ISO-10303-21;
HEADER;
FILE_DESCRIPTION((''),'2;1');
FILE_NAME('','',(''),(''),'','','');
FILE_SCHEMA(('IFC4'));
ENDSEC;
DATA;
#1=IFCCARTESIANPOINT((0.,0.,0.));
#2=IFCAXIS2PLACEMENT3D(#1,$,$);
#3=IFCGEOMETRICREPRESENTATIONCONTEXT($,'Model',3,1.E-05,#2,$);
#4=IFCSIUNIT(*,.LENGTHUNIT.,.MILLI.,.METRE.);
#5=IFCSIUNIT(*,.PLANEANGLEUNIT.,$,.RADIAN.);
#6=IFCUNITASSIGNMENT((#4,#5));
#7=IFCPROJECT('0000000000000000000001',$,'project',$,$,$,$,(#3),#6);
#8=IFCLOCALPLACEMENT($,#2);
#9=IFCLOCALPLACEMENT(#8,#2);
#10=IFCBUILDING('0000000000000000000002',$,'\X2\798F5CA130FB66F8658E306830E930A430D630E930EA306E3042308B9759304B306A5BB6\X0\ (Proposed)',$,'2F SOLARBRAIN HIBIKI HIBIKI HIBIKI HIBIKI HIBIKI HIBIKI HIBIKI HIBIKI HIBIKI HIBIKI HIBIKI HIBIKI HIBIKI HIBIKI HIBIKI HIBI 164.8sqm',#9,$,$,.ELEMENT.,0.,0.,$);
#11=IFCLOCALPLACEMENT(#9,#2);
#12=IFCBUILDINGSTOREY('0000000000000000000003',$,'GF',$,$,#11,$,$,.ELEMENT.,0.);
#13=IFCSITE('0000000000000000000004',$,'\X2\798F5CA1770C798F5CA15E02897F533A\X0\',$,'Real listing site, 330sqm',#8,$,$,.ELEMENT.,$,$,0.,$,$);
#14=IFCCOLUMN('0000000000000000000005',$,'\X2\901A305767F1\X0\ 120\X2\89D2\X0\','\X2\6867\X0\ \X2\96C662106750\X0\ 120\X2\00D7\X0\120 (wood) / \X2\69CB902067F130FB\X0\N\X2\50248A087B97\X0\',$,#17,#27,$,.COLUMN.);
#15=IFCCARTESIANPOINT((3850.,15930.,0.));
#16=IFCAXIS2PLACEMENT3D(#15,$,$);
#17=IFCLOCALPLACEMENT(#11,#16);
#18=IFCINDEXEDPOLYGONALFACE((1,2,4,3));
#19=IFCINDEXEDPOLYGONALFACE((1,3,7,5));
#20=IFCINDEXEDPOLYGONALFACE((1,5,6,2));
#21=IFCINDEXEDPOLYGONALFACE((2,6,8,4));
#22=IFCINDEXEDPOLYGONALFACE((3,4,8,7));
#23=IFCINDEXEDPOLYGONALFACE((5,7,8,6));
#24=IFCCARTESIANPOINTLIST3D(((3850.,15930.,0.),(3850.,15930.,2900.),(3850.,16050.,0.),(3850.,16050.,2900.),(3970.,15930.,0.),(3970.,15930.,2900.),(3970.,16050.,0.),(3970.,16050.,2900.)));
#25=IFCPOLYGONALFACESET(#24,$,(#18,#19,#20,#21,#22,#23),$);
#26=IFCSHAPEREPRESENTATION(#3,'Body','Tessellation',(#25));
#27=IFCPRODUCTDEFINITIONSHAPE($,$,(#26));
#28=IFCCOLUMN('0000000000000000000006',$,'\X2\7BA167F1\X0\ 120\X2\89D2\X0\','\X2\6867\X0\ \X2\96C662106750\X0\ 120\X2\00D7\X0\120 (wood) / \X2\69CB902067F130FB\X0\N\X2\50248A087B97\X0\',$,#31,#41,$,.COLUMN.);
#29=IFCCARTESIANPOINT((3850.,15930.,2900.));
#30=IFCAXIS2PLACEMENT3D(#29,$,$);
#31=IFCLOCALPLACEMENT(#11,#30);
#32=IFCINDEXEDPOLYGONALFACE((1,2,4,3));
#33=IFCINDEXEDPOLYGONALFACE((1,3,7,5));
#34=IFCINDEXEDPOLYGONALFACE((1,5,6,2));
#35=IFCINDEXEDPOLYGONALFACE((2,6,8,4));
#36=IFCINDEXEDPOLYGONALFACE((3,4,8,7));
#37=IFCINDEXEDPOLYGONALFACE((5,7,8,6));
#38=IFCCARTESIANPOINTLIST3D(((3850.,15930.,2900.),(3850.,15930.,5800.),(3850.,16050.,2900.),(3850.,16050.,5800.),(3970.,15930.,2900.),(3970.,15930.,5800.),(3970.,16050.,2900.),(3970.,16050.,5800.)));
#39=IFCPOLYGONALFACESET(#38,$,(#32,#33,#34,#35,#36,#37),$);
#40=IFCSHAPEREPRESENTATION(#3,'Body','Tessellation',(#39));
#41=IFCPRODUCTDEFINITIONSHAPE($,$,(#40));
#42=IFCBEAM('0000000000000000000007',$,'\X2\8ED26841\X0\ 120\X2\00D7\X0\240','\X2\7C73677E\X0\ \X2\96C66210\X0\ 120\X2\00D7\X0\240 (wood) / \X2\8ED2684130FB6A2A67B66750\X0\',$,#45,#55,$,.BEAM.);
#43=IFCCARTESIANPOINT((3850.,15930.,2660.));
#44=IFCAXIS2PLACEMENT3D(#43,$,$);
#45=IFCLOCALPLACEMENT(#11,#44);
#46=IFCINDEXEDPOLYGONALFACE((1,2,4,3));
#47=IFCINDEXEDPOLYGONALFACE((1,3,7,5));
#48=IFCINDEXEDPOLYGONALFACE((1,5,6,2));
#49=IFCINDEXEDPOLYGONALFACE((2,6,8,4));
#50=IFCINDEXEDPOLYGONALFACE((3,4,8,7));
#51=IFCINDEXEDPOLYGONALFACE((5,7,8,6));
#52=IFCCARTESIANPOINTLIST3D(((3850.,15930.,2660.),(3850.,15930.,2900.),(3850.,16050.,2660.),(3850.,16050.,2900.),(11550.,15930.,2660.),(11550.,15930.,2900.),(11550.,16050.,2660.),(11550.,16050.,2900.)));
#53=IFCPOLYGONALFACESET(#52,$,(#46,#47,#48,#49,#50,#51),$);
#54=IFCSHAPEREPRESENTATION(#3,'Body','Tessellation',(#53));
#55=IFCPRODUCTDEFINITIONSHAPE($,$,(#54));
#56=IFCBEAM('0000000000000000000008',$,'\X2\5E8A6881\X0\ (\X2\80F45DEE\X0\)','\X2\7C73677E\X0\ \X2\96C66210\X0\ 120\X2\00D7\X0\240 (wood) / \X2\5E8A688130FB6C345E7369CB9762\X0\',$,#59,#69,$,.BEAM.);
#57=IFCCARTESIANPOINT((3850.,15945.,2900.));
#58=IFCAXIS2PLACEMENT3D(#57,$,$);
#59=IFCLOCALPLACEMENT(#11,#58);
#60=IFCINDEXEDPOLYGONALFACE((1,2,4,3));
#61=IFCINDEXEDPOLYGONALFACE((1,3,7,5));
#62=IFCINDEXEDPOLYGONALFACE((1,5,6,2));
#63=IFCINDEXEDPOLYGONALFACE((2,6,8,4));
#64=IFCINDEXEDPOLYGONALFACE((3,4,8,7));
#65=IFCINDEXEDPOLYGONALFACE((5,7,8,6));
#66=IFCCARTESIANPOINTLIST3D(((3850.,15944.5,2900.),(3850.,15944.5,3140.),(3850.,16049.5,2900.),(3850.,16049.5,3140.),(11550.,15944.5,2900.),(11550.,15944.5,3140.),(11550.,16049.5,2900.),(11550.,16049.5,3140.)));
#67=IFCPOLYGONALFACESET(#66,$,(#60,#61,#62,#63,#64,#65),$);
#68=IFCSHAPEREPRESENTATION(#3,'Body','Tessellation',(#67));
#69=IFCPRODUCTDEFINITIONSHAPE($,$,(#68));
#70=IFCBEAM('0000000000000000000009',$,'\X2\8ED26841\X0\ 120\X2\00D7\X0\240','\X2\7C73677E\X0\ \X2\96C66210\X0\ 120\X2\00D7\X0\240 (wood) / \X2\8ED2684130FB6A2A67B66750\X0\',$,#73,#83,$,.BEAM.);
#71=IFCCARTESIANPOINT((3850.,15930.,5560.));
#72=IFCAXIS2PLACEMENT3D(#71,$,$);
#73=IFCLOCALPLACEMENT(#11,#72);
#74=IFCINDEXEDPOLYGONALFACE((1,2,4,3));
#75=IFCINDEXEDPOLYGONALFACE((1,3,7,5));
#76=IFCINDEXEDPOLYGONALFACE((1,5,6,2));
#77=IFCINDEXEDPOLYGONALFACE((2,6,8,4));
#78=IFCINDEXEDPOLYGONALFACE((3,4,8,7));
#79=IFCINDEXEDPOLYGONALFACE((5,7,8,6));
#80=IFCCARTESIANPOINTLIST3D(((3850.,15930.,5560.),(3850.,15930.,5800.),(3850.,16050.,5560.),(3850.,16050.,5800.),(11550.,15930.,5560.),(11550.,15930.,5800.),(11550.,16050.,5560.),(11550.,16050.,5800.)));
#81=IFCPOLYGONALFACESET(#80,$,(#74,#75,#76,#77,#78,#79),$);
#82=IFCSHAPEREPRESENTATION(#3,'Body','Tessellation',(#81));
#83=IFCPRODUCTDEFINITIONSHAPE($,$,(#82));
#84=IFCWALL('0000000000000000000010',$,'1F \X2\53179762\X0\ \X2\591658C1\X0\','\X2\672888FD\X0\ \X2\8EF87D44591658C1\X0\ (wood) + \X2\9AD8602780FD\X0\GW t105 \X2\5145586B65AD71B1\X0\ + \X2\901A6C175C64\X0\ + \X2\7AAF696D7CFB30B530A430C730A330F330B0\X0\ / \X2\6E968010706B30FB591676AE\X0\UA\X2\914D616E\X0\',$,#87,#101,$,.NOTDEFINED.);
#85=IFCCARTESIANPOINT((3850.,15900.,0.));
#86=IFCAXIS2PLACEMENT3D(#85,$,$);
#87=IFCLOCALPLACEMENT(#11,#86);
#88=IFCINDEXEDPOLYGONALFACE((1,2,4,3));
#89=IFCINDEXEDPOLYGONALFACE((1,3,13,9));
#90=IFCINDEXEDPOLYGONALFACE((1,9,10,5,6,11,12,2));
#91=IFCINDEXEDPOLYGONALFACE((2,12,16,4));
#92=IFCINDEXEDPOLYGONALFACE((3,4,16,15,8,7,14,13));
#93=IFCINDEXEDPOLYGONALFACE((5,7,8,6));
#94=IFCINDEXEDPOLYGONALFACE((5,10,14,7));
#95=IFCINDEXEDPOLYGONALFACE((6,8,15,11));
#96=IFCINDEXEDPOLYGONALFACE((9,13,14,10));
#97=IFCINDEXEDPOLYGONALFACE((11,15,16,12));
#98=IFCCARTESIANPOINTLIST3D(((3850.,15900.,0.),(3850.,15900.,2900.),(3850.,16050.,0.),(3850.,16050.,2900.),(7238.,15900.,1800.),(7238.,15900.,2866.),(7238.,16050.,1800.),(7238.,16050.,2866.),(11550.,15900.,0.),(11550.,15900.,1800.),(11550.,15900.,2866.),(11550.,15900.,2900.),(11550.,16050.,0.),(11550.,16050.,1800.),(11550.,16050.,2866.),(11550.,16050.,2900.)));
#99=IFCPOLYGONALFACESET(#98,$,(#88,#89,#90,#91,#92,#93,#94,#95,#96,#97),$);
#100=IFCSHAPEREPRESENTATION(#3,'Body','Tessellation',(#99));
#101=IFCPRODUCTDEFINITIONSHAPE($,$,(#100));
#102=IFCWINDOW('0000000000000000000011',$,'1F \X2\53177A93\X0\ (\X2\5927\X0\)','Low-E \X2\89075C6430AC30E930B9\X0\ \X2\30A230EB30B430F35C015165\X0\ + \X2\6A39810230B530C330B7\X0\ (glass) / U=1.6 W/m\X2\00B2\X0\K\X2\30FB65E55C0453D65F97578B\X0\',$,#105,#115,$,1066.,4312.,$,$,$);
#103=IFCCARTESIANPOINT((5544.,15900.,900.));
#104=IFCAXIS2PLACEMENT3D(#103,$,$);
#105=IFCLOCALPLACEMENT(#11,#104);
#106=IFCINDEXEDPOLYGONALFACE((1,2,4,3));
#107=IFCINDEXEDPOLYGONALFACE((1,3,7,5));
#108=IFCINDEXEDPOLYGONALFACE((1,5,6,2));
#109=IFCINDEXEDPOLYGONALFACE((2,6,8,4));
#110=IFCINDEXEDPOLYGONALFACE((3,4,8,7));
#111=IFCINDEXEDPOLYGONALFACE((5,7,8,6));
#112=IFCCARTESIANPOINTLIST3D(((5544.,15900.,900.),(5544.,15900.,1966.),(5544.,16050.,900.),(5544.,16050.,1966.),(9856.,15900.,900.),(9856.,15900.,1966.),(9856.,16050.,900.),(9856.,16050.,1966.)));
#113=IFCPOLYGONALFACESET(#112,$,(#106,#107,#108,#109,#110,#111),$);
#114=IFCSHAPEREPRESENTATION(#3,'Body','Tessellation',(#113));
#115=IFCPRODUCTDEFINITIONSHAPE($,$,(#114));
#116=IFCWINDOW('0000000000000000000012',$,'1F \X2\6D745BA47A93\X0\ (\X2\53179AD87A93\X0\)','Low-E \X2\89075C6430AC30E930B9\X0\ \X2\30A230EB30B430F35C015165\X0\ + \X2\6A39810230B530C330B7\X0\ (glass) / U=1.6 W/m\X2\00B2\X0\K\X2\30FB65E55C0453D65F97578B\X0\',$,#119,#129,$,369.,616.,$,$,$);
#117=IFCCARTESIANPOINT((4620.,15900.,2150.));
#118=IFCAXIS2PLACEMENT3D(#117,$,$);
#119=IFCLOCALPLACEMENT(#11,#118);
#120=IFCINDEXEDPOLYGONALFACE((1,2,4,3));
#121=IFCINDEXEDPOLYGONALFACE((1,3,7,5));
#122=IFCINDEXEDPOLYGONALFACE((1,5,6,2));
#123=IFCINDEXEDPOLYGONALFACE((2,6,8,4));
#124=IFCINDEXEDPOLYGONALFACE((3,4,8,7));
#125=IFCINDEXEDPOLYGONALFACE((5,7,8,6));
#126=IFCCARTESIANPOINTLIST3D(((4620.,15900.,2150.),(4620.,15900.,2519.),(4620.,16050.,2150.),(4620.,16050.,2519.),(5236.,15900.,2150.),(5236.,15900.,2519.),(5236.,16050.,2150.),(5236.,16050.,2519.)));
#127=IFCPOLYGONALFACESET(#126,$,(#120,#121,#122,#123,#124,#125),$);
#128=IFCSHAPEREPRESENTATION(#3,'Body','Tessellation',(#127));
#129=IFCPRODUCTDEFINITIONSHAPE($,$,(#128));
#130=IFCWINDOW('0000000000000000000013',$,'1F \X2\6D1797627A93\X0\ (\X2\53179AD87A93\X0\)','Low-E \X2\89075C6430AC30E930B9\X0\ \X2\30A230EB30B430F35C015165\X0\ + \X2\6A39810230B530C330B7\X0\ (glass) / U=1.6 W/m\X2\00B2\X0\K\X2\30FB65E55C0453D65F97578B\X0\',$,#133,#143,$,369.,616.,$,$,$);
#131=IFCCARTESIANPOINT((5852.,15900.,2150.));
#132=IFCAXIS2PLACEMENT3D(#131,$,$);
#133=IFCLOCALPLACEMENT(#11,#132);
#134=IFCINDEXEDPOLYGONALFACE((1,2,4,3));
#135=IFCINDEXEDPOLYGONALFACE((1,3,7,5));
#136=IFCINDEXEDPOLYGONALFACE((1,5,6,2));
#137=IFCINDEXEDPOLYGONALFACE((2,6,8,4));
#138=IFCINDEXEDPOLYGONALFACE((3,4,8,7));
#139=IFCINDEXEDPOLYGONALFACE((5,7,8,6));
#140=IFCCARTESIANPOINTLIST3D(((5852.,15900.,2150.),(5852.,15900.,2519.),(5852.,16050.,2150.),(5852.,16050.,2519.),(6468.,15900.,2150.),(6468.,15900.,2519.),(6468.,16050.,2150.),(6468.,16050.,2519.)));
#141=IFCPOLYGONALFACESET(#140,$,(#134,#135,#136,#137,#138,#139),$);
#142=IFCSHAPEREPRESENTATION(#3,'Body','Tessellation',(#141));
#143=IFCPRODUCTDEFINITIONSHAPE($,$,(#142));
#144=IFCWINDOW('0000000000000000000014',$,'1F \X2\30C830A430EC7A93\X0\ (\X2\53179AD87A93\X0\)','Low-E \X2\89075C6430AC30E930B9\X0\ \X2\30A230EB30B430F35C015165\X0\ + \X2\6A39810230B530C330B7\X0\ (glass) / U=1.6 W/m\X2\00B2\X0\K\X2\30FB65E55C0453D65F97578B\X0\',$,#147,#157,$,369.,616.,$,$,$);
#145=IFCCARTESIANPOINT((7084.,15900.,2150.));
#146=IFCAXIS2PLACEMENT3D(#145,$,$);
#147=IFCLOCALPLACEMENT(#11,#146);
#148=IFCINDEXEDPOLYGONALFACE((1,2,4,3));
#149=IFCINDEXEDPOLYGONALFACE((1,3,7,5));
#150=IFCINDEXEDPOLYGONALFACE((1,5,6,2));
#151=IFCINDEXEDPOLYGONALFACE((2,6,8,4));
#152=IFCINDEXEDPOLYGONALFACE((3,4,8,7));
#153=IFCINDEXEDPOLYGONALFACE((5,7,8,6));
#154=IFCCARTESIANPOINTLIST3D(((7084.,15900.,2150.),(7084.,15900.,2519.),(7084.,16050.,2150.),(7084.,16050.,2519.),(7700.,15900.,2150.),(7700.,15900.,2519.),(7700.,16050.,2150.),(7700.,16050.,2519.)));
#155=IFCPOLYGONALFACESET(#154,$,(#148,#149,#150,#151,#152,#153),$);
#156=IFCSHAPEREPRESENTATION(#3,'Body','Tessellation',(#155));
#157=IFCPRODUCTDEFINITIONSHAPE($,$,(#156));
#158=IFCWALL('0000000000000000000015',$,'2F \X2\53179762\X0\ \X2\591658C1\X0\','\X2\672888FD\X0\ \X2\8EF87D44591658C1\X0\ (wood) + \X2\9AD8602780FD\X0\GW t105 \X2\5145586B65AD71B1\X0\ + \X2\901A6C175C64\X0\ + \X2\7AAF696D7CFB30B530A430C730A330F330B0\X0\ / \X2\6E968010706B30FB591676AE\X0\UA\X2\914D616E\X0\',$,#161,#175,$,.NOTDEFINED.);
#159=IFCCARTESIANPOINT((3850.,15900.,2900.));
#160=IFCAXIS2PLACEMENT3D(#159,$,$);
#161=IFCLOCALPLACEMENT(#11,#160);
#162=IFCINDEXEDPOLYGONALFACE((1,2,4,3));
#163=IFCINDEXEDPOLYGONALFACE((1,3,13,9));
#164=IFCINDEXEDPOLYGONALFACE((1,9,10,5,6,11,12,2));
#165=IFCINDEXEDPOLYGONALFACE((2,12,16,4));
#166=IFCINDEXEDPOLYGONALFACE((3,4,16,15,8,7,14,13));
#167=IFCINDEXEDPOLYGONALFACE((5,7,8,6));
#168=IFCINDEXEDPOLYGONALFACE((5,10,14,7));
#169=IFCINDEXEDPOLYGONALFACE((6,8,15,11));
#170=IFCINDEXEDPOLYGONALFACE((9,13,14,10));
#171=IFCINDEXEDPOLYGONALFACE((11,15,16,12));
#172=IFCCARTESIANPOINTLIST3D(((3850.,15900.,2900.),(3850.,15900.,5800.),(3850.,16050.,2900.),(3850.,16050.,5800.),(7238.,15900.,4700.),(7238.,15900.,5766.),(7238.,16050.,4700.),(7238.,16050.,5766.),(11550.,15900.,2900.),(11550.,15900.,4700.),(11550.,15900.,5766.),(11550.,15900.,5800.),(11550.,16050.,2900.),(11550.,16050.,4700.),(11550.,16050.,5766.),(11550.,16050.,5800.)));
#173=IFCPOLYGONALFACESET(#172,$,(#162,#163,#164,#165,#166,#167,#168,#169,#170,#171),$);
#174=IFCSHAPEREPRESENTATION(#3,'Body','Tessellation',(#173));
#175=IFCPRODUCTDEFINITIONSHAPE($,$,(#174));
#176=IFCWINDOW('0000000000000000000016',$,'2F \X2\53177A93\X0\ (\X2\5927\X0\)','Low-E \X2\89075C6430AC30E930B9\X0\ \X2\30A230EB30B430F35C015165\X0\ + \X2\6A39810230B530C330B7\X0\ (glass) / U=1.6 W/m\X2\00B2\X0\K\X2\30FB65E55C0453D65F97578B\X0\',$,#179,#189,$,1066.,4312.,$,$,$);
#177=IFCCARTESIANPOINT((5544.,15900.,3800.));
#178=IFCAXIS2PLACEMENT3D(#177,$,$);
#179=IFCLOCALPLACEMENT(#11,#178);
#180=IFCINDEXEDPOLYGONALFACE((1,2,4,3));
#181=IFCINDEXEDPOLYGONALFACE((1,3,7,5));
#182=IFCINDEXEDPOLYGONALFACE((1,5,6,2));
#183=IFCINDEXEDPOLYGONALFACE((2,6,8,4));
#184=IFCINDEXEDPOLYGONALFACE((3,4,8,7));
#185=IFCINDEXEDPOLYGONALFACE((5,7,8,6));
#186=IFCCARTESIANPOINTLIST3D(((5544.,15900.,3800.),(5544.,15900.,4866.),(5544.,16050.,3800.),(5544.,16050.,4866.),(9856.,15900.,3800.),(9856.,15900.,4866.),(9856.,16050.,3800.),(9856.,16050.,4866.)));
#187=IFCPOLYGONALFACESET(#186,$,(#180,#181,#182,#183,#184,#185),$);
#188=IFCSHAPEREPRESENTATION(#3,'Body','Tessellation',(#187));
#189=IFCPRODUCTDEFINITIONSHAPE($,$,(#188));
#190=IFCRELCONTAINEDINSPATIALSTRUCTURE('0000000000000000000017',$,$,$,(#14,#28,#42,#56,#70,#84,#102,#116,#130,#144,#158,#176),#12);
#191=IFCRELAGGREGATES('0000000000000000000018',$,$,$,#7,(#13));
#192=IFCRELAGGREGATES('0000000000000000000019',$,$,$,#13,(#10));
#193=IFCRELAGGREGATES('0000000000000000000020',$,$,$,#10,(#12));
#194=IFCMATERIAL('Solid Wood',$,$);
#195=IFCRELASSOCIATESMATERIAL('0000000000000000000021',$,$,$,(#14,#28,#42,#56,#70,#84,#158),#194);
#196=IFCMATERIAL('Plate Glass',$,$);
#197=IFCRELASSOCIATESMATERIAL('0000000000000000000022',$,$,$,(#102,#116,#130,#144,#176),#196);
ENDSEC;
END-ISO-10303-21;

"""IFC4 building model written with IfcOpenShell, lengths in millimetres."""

from ifc_helpers import new_model, si_unit, frame, frame_2d, origin, place, context, project, spatial, rectangle, extrude, material, element, fill, save


model = new_model("IFC4")

# Units and contexts
model_context = context("Model", 3, precision=1e-05, world=origin())
ifc_project = project(units=[si_unit("LENGTHUNIT", "METRE", prefix="MILLI"), si_unit("PLANEANGLEUNIT", "RADIAN")], contexts=[model_context])

# Site, building, storey
site_placement = place(None, origin())
site = spatial("IfcSite", under=ifc_project, at=site_placement, Name="福岡県福岡市西区", ObjectType="Real listing site, 330sqm", CompositionType="ELEMENT", RefElevation=0.0)
building_placement = place(site_placement, origin())
building = spatial("IfcBuilding", under=site, at=building_placement, Name="福岡・書斎とライブラリのある静かな家 (Proposed)", ObjectType="2F SOLARBRAIN HIBIKI HIBIKI HIBIKI HIBIKI HIBIKI HIBIKI HIBIKI HIBIKI HIBIKI HIBIKI HIBIKI HIBIKI HIBIKI HIBIKI HIBIKI HIBI 164.8sqm", CompositionType="ELEMENT", ElevationOfRefHeight=0.0, ElevationOfTerrain=0.0)
storey_placement = place(building_placement, origin())
storey = spatial("IfcBuildingStorey", under=building, at=storey_placement, Name="GF", CompositionType="ELEMENT", Elevation=0.0)

# Columns
ifc_material_1 = material(Name="Solid Wood")
column_1_placement = place(storey_placement, frame((3850.0, 15930.0, 0.0)))
element("IfcColumn", 1, at=column_1_placement, inside=storey, material=ifc_material_1, Name="通し柱 120角", Description="桧 集成材 120×120 (wood) / 構造柱・N値計算", PredefinedType="COLUMN", context=model_context, shape_type="SweptSolid", body=[
    extrude(rectangle(XDim=120.0, YDim=120.0, at=frame_2d((60.0, 60.0))), frame((3850.0, 15930.0, 0.0)), (0.0, 0.0, 1.0), 2900.0),
])
column_2_placement = place(storey_placement, frame((3850.0, 15930.0, 2900.0)))
element("IfcColumn", 2, at=column_2_placement, inside=storey, material=ifc_material_1, Name="管柱 120角", Description="桧 集成材 120×120 (wood) / 構造柱・N値計算", PredefinedType="COLUMN", context=model_context, shape_type="SweptSolid", body=[
    extrude(rectangle(XDim=120.0, YDim=120.0, at=frame_2d((60.0, 60.0))), frame((3850.0, 15930.0, 2900.0)), (0.0, 0.0, 1.0), 2900.0),
])

# Beams
beam_1_placement = place(storey_placement, frame((3850.0, 15930.0, 2660.0)))
element("IfcBeam", 3, at=beam_1_placement, inside=storey, material=ifc_material_1, Name="軒桁 120×240", Description="米松 集成 120×240 (wood) / 軒桁・横架材", PredefinedType="BEAM", context=model_context, shape_type="SweptSolid", body=[
    extrude(rectangle(XDim=7700.0, YDim=120.0, at=frame_2d((3850.0, 60.0))), frame((3850.0, 15930.0, 2660.0)), (0.0, 0.0, 1.0), 240.0),
])
beam_2_placement = place(storey_placement, frame((3850.0, 15945.0, 2900.0)))
element("IfcBeam", 4, at=beam_2_placement, inside=storey, material=ifc_material_1, Name="床梁 (胴差)", Description="米松 集成 120×240 (wood) / 床梁・水平構面", PredefinedType="BEAM", context=model_context, shape_type="SweptSolid", body=[
    extrude(rectangle(XDim=7700.0, YDim=105.0, at=frame_2d((3850.0, 52.0))), frame((3850.0, 15945.0, 2900.0)), (0.0, 0.0, 1.0), 240.0),
])
beam_3_placement = place(storey_placement, frame((3850.0, 15930.0, 5560.0)))
element("IfcBeam", 5, at=beam_3_placement, inside=storey, material=ifc_material_1, Name="軒桁 120×240", Description="米松 集成 120×240 (wood) / 軒桁・横架材", PredefinedType="BEAM", context=model_context, shape_type="SweptSolid", body=[
    extrude(rectangle(XDim=7700.0, YDim=120.0, at=frame_2d((3850.0, 60.0))), frame((3850.0, 15930.0, 5560.0)), (0.0, 0.0, 1.0), 240.0),
])

# Wall, openings, windows
wall_1_placement = place(storey_placement, frame((3850.0, 15900.0, 0.0)))
wall_1 = element("IfcWall", 6, at=wall_1_placement, inside=storey, material=ifc_material_1, Name="1F 北面 外壁", Description="木製 軸組外壁 (wood) + 高性能GW t105 充填断熱 + 通気層 + 窯業系サイディング / 準耐火・外皮UA配慮", PredefinedType="NOTDEFINED", context=model_context, shape_type="SweptSolid", body=[
    extrude(rectangle(XDim=7700.0, YDim=150.0, at=frame_2d((3850.0, 75.0))), frame((3850.0, 15900.0, 0.0)), (0.0, 0.0, 1.0), 2900.0),
])
opening_1_placement = place(storey_placement, frame((5544.0, 15900.0, 900.0)))
opening_1 = element("IfcOpeningElement", 7, at=opening_1_placement, cuts=wall_1, PredefinedType="NOTDEFINED", context=model_context, shape_type="SweptSolid", body=[
    extrude(rectangle(XDim=4312.0, YDim=150.0, at=frame_2d((2156.0, 75.0))), frame((5544.0, 15900.0, 900.0)), (0.0, 0.0, 1.0), 1066.0),
])
opening_2_placement = place(storey_placement, frame((4620.0, 15900.0, 2150.0)))
opening_2 = element("IfcOpeningElement", 8, at=opening_2_placement, cuts=wall_1, PredefinedType="NOTDEFINED", context=model_context, shape_type="SweptSolid", body=[
    extrude(rectangle(XDim=616.0, YDim=150.0, at=frame_2d((308.0, 75.0))), frame((4620.0, 15900.0, 2150.0)), (0.0, 0.0, 1.0), 369.0),
])
opening_3_placement = place(storey_placement, frame((5852.0, 15900.0, 2150.0)))
opening_3 = element("IfcOpeningElement", 9, at=opening_3_placement, cuts=wall_1, PredefinedType="NOTDEFINED", context=model_context, shape_type="SweptSolid", body=[
    extrude(rectangle(XDim=616.0, YDim=150.0, at=frame_2d((308.0, 75.0))), frame((5852.0, 15900.0, 2150.0)), (0.0, 0.0, 1.0), 369.0),
])
opening_4_placement = place(storey_placement, frame((7084.0, 15900.0, 2150.0)))
opening_4 = element("IfcOpeningElement", 10, at=opening_4_placement, cuts=wall_1, PredefinedType="NOTDEFINED", context=model_context, shape_type="SweptSolid", body=[
    extrude(rectangle(XDim=616.0, YDim=150.0, at=frame_2d((308.0, 75.0))), frame((7084.0, 15900.0, 2150.0)), (0.0, 0.0, 1.0), 369.0),
])
ifc_material_2 = material(Name="Plate Glass")
window_1_placement = place(storey_placement, frame((5544.0, 15900.0, 900.0)))
window_1 = element("IfcWindow", 11, at=window_1_placement, inside=storey, material=ifc_material_2, Name="1F 北窓 (大)", Description="Low-E 複層ガラス アルゴン封入 + 樹脂サッシ (glass) / U=1.6 W/m²K・日射取得型", OverallHeight=1066.0, OverallWidth=4312.0, context=model_context, shape_type="SweptSolid", body=[
    extrude(rectangle(XDim=4312.0, YDim=150.0, at=frame_2d((2156.0, 75.0))), frame((5544.0, 15900.0, 900.0)), (0.0, 0.0, 1.0), 1066.0),
])
fill(opening_1, window_1)
window_2_placement = place(storey_placement, frame((4620.0, 15900.0, 2150.0)))
window_2 = element("IfcWindow", 12, at=window_2_placement, inside=storey, material=ifc_material_2, Name="1F 浴室窓 (北高窓)", Description="Low-E 複層ガラス アルゴン封入 + 樹脂サッシ (glass) / U=1.6 W/m²K・日射取得型", OverallHeight=369.0, OverallWidth=616.0, context=model_context, shape_type="SweptSolid", body=[
    extrude(rectangle(XDim=616.0, YDim=150.0, at=frame_2d((308.0, 75.0))), frame((4620.0, 15900.0, 2150.0)), (0.0, 0.0, 1.0), 369.0),
])
fill(opening_2, window_2)
window_3_placement = place(storey_placement, frame((5852.0, 15900.0, 2150.0)))
window_3 = element("IfcWindow", 13, at=window_3_placement, inside=storey, material=ifc_material_2, Name="1F 洗面窓 (北高窓)", Description="Low-E 複層ガラス アルゴン封入 + 樹脂サッシ (glass) / U=1.6 W/m²K・日射取得型", OverallHeight=369.0, OverallWidth=616.0, context=model_context, shape_type="SweptSolid", body=[
    extrude(rectangle(XDim=616.0, YDim=150.0, at=frame_2d((308.0, 75.0))), frame((5852.0, 15900.0, 2150.0)), (0.0, 0.0, 1.0), 369.0),
])
fill(opening_3, window_3)
window_4_placement = place(storey_placement, frame((7084.0, 15900.0, 2150.0)))
window_4 = element("IfcWindow", 14, at=window_4_placement, inside=storey, material=ifc_material_2, Name="1F トイレ窓 (北高窓)", Description="Low-E 複層ガラス アルゴン封入 + 樹脂サッシ (glass) / U=1.6 W/m²K・日射取得型", OverallHeight=369.0, OverallWidth=616.0, context=model_context, shape_type="SweptSolid", body=[
    extrude(rectangle(XDim=616.0, YDim=150.0, at=frame_2d((308.0, 75.0))), frame((7084.0, 15900.0, 2150.0)), (0.0, 0.0, 1.0), 369.0),
])
fill(opening_4, window_4)

# Wall, opening, window
wall_2_placement = place(storey_placement, frame((3850.0, 15900.0, 2900.0)))
wall_2 = element("IfcWall", 15, at=wall_2_placement, inside=storey, material=ifc_material_1, Name="2F 北面 外壁", Description="木製 軸組外壁 (wood) + 高性能GW t105 充填断熱 + 通気層 + 窯業系サイディング / 準耐火・外皮UA配慮", PredefinedType="NOTDEFINED", context=model_context, shape_type="SweptSolid", body=[
    extrude(rectangle(XDim=7700.0, YDim=150.0, at=frame_2d((3850.0, 75.0))), frame((3850.0, 15900.0, 2900.0)), (0.0, 0.0, 1.0), 2900.0),
])
opening_5_placement = place(storey_placement, frame((5544.0, 15900.0, 3800.0)))
opening_5 = element("IfcOpeningElement", 16, at=opening_5_placement, cuts=wall_2, PredefinedType="NOTDEFINED", context=model_context, shape_type="SweptSolid", body=[
    extrude(rectangle(XDim=4312.0, YDim=150.0, at=frame_2d((2156.0, 75.0))), frame((5544.0, 15900.0, 3800.0)), (0.0, 0.0, 1.0), 1066.0),
])
window_5_placement = place(storey_placement, frame((5544.0, 15900.0, 3800.0)))
window_5 = element("IfcWindow", 17, at=window_5_placement, inside=storey, material=ifc_material_2, Name="2F 北窓 (大)", Description="Low-E 複層ガラス アルゴン封入 + 樹脂サッシ (glass) / U=1.6 W/m²K・日射取得型", OverallHeight=1066.0, OverallWidth=4312.0, context=model_context, shape_type="SweptSolid", body=[
    extrude(rectangle(XDim=4312.0, YDim=150.0, at=frame_2d((2156.0, 75.0))), frame((5544.0, 15900.0, 3800.0)), (0.0, 0.0, 1.0), 1066.0),
])
fill(opening_5, window_5)

save(model, "model.ifc")
